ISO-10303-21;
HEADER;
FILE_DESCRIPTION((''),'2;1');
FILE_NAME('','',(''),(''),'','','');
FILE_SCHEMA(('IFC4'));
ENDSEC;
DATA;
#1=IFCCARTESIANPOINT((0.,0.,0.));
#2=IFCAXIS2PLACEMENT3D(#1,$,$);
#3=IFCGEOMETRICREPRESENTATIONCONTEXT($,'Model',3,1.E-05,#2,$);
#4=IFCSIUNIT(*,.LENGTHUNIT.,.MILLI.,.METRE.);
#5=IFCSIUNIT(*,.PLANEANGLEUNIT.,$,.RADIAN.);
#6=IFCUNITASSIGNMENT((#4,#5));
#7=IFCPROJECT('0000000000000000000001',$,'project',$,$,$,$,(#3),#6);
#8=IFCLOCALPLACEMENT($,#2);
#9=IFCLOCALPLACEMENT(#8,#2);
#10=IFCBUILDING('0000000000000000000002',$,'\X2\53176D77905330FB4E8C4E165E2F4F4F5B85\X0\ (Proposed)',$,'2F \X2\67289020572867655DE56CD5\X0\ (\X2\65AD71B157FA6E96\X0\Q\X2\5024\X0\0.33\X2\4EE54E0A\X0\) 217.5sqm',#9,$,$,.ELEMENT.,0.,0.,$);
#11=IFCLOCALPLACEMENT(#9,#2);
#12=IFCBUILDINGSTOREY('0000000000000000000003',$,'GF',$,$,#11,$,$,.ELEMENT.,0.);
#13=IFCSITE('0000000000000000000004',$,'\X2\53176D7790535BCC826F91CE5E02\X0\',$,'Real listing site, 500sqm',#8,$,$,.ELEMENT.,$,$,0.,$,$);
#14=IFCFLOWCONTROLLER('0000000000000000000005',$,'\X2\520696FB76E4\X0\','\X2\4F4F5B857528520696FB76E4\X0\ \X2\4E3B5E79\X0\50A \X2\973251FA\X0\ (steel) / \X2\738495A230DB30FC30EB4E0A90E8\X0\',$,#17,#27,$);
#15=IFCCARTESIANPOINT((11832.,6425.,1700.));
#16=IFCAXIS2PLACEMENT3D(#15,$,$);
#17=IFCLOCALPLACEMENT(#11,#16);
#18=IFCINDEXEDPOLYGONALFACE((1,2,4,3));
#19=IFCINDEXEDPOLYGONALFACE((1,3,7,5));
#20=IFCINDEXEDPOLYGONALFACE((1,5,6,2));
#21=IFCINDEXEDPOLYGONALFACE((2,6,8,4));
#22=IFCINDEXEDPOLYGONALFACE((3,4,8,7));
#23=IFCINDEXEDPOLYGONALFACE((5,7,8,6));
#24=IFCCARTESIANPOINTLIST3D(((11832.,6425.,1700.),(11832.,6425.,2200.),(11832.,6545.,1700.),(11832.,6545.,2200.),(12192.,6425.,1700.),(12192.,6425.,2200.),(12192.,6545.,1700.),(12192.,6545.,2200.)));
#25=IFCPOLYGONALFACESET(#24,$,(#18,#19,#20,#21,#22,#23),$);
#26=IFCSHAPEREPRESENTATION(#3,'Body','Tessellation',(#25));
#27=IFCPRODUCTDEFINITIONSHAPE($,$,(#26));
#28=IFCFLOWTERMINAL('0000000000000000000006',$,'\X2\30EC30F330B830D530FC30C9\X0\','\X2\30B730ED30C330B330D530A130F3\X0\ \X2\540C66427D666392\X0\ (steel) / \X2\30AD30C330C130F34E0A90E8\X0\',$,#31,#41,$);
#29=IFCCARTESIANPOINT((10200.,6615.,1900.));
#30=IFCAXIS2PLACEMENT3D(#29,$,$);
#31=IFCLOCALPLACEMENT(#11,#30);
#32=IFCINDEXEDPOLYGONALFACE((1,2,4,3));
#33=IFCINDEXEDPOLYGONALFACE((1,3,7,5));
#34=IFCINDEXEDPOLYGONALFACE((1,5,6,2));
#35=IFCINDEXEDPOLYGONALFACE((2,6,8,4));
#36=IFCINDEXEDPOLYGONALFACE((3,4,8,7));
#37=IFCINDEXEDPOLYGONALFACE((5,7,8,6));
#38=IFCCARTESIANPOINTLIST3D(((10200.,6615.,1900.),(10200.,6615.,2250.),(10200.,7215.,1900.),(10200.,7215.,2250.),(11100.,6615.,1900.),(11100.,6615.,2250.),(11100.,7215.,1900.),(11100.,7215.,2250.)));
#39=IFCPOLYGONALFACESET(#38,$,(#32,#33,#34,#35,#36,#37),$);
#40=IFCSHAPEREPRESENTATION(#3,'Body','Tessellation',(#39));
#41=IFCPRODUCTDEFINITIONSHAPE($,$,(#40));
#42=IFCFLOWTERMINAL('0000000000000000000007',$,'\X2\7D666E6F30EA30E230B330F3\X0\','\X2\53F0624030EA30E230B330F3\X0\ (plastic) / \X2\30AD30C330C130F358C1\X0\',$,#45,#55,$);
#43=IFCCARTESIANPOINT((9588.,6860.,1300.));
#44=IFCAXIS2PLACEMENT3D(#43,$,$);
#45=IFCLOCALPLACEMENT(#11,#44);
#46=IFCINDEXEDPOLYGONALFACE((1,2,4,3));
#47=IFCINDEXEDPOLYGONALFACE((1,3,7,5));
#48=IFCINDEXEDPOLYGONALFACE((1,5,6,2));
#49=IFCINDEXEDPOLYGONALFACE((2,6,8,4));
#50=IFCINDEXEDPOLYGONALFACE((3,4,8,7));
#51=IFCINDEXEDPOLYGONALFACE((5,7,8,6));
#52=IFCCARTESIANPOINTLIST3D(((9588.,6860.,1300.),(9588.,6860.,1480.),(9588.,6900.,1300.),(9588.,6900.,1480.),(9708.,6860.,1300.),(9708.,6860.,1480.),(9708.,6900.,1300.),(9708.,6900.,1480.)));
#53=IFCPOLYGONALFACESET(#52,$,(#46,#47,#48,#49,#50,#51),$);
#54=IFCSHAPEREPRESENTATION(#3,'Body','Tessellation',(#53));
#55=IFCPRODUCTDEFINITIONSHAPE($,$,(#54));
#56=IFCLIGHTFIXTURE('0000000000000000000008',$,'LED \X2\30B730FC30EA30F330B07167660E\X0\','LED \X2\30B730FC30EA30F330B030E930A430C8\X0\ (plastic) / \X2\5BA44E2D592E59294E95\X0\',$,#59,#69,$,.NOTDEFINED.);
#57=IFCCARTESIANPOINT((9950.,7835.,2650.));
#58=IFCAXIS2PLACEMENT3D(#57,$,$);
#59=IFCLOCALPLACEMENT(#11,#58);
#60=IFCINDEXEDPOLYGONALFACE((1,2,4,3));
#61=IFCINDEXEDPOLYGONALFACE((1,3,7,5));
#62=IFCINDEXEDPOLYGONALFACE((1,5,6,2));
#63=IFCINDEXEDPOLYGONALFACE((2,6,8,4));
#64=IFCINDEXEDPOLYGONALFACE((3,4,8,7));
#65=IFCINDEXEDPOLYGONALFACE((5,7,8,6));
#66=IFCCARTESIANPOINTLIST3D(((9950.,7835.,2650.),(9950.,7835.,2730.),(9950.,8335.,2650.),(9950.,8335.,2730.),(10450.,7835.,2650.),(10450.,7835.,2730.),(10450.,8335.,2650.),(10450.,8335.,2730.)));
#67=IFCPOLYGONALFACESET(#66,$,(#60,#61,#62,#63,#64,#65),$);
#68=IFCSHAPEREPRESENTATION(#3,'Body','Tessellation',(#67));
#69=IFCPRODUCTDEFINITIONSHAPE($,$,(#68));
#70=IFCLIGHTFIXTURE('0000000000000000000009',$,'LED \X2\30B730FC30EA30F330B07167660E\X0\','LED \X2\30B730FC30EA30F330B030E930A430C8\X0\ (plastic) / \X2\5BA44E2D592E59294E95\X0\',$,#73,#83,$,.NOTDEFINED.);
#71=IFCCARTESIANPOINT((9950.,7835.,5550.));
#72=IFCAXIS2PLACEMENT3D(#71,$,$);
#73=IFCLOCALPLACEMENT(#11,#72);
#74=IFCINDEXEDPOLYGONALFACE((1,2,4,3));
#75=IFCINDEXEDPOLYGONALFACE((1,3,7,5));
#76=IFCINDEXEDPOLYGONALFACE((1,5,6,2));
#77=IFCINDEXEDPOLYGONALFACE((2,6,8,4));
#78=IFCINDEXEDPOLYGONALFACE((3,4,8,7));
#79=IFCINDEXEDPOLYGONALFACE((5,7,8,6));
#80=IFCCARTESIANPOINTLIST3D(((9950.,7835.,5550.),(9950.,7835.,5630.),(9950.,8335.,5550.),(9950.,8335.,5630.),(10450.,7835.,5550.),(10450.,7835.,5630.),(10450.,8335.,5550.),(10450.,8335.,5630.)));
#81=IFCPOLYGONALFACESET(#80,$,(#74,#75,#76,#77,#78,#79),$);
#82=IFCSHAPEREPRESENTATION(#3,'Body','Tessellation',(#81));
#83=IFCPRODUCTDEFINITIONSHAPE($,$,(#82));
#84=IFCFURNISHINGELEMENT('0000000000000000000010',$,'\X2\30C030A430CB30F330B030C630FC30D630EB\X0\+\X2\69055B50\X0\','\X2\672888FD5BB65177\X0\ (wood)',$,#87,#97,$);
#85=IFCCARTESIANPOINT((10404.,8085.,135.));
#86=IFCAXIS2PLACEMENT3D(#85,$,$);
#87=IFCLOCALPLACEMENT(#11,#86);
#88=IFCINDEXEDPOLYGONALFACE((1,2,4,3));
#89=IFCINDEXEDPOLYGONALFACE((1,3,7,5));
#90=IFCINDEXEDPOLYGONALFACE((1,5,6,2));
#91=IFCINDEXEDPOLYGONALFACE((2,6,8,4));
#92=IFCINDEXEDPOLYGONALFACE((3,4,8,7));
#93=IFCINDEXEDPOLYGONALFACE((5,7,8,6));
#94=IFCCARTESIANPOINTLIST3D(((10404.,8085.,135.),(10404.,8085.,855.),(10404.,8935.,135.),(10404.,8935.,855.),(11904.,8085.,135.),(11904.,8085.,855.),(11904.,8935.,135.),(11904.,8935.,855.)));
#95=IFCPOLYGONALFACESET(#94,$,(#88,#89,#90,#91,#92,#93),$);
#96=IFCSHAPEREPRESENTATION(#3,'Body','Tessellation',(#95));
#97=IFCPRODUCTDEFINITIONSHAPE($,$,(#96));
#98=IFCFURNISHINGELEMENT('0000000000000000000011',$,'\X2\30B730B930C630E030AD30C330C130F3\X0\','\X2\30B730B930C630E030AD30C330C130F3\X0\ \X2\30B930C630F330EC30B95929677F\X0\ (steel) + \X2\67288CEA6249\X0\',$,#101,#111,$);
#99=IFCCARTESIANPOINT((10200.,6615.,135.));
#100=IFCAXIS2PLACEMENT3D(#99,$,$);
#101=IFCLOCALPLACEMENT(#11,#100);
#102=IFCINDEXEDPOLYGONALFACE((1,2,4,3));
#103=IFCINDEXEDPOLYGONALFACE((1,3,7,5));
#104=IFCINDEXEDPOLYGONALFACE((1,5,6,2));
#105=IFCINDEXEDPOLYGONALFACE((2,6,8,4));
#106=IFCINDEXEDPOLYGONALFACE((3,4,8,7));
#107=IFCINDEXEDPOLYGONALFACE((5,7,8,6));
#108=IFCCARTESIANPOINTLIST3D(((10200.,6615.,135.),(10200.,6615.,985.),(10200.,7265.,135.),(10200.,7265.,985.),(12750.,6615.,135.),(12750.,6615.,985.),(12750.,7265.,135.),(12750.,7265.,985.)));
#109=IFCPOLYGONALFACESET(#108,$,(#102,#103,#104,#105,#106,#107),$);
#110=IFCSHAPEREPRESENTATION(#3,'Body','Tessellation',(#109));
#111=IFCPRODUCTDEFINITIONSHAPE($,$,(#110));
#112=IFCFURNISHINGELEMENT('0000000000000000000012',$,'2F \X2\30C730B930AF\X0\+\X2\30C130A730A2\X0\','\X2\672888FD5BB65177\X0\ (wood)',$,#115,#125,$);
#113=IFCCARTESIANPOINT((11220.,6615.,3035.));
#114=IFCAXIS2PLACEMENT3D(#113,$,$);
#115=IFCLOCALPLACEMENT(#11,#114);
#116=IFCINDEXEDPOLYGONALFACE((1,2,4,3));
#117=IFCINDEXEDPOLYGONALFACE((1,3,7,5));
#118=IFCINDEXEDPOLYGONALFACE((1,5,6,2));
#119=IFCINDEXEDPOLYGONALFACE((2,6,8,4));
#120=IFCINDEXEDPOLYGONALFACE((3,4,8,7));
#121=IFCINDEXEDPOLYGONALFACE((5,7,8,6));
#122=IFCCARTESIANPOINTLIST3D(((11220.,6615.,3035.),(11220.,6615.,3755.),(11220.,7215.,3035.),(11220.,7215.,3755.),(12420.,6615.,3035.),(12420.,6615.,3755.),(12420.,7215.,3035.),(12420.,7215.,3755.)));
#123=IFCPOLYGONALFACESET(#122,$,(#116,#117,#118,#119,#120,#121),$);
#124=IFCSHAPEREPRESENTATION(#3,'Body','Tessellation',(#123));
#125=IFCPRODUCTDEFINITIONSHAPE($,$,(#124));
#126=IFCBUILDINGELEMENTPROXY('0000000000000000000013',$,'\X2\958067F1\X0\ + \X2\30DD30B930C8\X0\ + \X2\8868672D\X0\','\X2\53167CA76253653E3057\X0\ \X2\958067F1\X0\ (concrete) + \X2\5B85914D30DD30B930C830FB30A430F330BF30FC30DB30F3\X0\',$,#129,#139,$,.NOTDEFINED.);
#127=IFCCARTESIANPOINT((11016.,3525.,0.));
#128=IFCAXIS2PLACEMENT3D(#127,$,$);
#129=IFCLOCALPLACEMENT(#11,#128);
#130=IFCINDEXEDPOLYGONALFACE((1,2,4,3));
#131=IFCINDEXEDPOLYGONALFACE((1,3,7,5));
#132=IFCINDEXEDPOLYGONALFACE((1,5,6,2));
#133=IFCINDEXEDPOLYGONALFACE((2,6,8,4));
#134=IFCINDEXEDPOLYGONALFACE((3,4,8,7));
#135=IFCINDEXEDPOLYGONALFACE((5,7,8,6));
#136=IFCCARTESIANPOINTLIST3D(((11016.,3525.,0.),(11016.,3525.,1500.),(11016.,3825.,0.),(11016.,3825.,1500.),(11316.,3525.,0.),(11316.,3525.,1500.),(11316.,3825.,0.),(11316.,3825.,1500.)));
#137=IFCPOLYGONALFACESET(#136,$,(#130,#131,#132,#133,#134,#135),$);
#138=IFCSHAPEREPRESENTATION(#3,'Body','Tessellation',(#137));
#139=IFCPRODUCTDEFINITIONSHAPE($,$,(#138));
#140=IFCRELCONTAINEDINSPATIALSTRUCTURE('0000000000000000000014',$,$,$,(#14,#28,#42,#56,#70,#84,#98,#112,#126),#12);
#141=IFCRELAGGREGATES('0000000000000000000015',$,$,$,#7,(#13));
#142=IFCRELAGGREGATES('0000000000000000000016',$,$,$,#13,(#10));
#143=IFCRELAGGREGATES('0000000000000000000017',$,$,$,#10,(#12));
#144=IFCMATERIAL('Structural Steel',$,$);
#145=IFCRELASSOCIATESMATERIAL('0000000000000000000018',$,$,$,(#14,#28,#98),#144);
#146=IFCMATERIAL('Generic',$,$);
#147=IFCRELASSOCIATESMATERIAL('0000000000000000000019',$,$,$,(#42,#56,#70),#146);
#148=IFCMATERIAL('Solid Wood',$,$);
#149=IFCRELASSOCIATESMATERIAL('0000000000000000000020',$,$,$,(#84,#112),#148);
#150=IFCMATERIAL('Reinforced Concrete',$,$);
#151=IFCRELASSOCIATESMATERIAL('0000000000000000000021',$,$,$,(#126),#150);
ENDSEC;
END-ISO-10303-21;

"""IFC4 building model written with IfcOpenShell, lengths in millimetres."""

from ifc_helpers import new_model, si_unit, frame, frame_2d, origin, place, context, project, spatial, rectangle, extrude, material, element, save


model = new_model("IFC4")

# Units and contexts
model_context = context("Model", 3, precision=1e-05, world=origin())
ifc_project = project(units=[si_unit("LENGTHUNIT", "METRE", prefix="MILLI"), si_unit("PLANEANGLEUNIT", "RADIAN")], contexts=[model_context])

# Site, building, storey
site_placement = place(None, origin())
site = spatial("IfcSite", under=ifc_project, at=site_placement, Name="北海道富良野市", ObjectType="Real listing site, 500sqm", CompositionType="ELEMENT", RefElevation=0.0)
building_placement = place(site_placement, origin())
building = spatial("IfcBuilding", under=site, at=building_placement, Name="北海道・二世帯住宅 (Proposed)", ObjectType="2F 木造在来工法 (断熱基準Q値0.33以上) 217.5sqm", CompositionType="ELEMENT", ElevationOfRefHeight=0.0, ElevationOfTerrain=0.0)
storey_placement = place(building_placement, origin())
storey = spatial("IfcBuildingStorey", under=building, at=storey_placement, Name="GF", CompositionType="ELEMENT", Elevation=0.0)

# Shared definitions
ifc_material_1 = material(Name="Solid Wood")

# Shared definitions
ifc_material_2 = material(Name="Structural Steel")

# Shared definitions
ifc_material_3 = material(Name="Reinforced Concrete")

# Flow controller
flow_controller_placement = place(storey_placement, frame((11832.0, 6425.0, 1700.0)))
element("IfcFlowController", 1, at=flow_controller_placement, inside=storey, material=ifc_material_2, Name="分電盤", Description="住宅用分電盤 主幹50A 露出 (steel) / 玄関ホール上部", context=model_context, shape_type="SweptSolid", body=[
    extrude(rectangle(XDim=360.0, YDim=120.0, at=frame_2d((180.0, 60.0))), frame((11832.0, 6425.0, 1700.0)), (0.0, 0.0, 1.0), 500.0),
])

# Flow terminals
flow_terminal_1_placement = place(storey_placement, frame((10200.0, 6615.0, 1900.0)))
element("IfcFlowTerminal", 2, at=flow_terminal_1_placement, inside=storey, material=ifc_material_2, Name="レンジフード", Description="シロッコファン 同時給排 (steel) / キッチン上部", context=model_context, shape_type="SweptSolid", body=[
    extrude(rectangle(XDim=900.0, YDim=600.0, at=frame_2d((450.0, 300.0))), frame((10200.0, 6615.0, 1900.0)), (0.0, 0.0, 1.0), 350.0),
])
ifc_material_4 = material(Name="Generic")
flow_terminal_2_placement = place(storey_placement, frame((9588.0, 6860.0, 1300.0)))
element("IfcFlowTerminal", 3, at=flow_terminal_2_placement, inside=storey, material=ifc_material_4, Name="給湯リモコン", Description="台所リモコン (plastic) / キッチン壁", context=model_context, shape_type="SweptSolid", body=[
    extrude(rectangle(XDim=120.0, YDim=40.0, at=frame_2d((60.0, 20.0))), frame((9588.0, 6860.0, 1300.0)), (0.0, 0.0, 1.0), 180.0),
])

# Light fixtures
light_fixture_1_placement = place(storey_placement, frame((9950.0, 7835.0, 2650.0)))
element("IfcLightFixture", 4, at=light_fixture_1_placement, inside=storey, material=ifc_material_4, Name="LED シーリング照明", Description="LED シーリングライト (plastic) / 室中央天井", PredefinedType="NOTDEFINED", context=model_context, shape_type="SweptSolid", body=[
    extrude(rectangle(XDim=500.0, YDim=500.0, at=frame_2d((250.0, 250.0))), frame((9950.0, 7835.0, 2650.0)), (0.0, 0.0, 1.0), 80.0),
])
light_fixture_2_placement = place(storey_placement, frame((9950.0, 7835.0, 5550.0)))
element("IfcLightFixture", 5, at=light_fixture_2_placement, inside=storey, material=ifc_material_4, Name="LED シーリング照明", Description="LED シーリングライト (plastic) / 室中央天井", PredefinedType="NOTDEFINED", context=model_context, shape_type="SweptSolid", body=[
    extrude(rectangle(XDim=500.0, YDim=500.0, at=frame_2d((250.0, 250.0))), frame((9950.0, 7835.0, 5550.0)), (0.0, 0.0, 1.0), 80.0),
])

# Furnishing elements
furnishing_1_placement = place(storey_placement, frame((10404.0, 8085.0, 135.0)))
element("IfcFurnishingElement", 6, at=furnishing_1_placement, inside=storey, material=ifc_material_1, Name="ダイニングテーブル+椅子", Description="木製家具 (wood)", context=model_context, shape_type="SweptSolid", body=[
    extrude(rectangle(XDim=1500.0, YDim=850.0, at=frame_2d((750.0, 425.0))), frame((10404.0, 8085.0, 135.0)), (0.0, 0.0, 1.0), 720.0),
])
furnishing_2_placement = place(storey_placement, frame((10200.0, 6615.0, 135.0)))
element("IfcFurnishingElement", 7, at=furnishing_2_placement, inside=storey, material=ifc_material_2, Name="システムキッチン", Description="システムキッチン ステンレス天板 (steel) + 木質扉", context=model_context, shape_type="SweptSolid", body=[
    extrude(rectangle(XDim=2550.0, YDim=650.0, at=frame_2d((1275.0, 325.0))), frame((10200.0, 6615.0, 135.0)), (0.0, 0.0, 1.0), 850.0),
])
furnishing_3_placement = place(storey_placement, frame((11220.0, 6615.0, 3035.0)))
element("IfcFurnishingElement", 8, at=furnishing_3_placement, inside=storey, material=ifc_material_1, Name="2F デスク+チェア", Description="木製家具 (wood)", context=model_context, shape_type="SweptSolid", body=[
    extrude(rectangle(XDim=1200.0, YDim=600.0, at=frame_2d((600.0, 300.0))), frame((11220.0, 6615.0, 3035.0)), (0.0, 0.0, 1.0), 720.0),
])

# Building element proxy
proxy_placement = place(storey_placement, frame((11016.0, 3525.0, 0.0)))
element("IfcBuildingElementProxy", 9, at=proxy_placement, inside=storey, material=ifc_material_3, Name="門柱 + ポスト + 表札", Description="化粧打放し 門柱 (concrete) + 宅配ポスト・インターホン", PredefinedType="NOTDEFINED", context=model_context, shape_type="SweptSolid", body=[
    extrude(rectangle(XDim=300.0, YDim=300.0, at=frame_2d((150.0, 150.0))), frame((11016.0, 3525.0, 0.0)), (0.0, 0.0, 1.0), 1500.0),
])

save(model, "model.ifc")
